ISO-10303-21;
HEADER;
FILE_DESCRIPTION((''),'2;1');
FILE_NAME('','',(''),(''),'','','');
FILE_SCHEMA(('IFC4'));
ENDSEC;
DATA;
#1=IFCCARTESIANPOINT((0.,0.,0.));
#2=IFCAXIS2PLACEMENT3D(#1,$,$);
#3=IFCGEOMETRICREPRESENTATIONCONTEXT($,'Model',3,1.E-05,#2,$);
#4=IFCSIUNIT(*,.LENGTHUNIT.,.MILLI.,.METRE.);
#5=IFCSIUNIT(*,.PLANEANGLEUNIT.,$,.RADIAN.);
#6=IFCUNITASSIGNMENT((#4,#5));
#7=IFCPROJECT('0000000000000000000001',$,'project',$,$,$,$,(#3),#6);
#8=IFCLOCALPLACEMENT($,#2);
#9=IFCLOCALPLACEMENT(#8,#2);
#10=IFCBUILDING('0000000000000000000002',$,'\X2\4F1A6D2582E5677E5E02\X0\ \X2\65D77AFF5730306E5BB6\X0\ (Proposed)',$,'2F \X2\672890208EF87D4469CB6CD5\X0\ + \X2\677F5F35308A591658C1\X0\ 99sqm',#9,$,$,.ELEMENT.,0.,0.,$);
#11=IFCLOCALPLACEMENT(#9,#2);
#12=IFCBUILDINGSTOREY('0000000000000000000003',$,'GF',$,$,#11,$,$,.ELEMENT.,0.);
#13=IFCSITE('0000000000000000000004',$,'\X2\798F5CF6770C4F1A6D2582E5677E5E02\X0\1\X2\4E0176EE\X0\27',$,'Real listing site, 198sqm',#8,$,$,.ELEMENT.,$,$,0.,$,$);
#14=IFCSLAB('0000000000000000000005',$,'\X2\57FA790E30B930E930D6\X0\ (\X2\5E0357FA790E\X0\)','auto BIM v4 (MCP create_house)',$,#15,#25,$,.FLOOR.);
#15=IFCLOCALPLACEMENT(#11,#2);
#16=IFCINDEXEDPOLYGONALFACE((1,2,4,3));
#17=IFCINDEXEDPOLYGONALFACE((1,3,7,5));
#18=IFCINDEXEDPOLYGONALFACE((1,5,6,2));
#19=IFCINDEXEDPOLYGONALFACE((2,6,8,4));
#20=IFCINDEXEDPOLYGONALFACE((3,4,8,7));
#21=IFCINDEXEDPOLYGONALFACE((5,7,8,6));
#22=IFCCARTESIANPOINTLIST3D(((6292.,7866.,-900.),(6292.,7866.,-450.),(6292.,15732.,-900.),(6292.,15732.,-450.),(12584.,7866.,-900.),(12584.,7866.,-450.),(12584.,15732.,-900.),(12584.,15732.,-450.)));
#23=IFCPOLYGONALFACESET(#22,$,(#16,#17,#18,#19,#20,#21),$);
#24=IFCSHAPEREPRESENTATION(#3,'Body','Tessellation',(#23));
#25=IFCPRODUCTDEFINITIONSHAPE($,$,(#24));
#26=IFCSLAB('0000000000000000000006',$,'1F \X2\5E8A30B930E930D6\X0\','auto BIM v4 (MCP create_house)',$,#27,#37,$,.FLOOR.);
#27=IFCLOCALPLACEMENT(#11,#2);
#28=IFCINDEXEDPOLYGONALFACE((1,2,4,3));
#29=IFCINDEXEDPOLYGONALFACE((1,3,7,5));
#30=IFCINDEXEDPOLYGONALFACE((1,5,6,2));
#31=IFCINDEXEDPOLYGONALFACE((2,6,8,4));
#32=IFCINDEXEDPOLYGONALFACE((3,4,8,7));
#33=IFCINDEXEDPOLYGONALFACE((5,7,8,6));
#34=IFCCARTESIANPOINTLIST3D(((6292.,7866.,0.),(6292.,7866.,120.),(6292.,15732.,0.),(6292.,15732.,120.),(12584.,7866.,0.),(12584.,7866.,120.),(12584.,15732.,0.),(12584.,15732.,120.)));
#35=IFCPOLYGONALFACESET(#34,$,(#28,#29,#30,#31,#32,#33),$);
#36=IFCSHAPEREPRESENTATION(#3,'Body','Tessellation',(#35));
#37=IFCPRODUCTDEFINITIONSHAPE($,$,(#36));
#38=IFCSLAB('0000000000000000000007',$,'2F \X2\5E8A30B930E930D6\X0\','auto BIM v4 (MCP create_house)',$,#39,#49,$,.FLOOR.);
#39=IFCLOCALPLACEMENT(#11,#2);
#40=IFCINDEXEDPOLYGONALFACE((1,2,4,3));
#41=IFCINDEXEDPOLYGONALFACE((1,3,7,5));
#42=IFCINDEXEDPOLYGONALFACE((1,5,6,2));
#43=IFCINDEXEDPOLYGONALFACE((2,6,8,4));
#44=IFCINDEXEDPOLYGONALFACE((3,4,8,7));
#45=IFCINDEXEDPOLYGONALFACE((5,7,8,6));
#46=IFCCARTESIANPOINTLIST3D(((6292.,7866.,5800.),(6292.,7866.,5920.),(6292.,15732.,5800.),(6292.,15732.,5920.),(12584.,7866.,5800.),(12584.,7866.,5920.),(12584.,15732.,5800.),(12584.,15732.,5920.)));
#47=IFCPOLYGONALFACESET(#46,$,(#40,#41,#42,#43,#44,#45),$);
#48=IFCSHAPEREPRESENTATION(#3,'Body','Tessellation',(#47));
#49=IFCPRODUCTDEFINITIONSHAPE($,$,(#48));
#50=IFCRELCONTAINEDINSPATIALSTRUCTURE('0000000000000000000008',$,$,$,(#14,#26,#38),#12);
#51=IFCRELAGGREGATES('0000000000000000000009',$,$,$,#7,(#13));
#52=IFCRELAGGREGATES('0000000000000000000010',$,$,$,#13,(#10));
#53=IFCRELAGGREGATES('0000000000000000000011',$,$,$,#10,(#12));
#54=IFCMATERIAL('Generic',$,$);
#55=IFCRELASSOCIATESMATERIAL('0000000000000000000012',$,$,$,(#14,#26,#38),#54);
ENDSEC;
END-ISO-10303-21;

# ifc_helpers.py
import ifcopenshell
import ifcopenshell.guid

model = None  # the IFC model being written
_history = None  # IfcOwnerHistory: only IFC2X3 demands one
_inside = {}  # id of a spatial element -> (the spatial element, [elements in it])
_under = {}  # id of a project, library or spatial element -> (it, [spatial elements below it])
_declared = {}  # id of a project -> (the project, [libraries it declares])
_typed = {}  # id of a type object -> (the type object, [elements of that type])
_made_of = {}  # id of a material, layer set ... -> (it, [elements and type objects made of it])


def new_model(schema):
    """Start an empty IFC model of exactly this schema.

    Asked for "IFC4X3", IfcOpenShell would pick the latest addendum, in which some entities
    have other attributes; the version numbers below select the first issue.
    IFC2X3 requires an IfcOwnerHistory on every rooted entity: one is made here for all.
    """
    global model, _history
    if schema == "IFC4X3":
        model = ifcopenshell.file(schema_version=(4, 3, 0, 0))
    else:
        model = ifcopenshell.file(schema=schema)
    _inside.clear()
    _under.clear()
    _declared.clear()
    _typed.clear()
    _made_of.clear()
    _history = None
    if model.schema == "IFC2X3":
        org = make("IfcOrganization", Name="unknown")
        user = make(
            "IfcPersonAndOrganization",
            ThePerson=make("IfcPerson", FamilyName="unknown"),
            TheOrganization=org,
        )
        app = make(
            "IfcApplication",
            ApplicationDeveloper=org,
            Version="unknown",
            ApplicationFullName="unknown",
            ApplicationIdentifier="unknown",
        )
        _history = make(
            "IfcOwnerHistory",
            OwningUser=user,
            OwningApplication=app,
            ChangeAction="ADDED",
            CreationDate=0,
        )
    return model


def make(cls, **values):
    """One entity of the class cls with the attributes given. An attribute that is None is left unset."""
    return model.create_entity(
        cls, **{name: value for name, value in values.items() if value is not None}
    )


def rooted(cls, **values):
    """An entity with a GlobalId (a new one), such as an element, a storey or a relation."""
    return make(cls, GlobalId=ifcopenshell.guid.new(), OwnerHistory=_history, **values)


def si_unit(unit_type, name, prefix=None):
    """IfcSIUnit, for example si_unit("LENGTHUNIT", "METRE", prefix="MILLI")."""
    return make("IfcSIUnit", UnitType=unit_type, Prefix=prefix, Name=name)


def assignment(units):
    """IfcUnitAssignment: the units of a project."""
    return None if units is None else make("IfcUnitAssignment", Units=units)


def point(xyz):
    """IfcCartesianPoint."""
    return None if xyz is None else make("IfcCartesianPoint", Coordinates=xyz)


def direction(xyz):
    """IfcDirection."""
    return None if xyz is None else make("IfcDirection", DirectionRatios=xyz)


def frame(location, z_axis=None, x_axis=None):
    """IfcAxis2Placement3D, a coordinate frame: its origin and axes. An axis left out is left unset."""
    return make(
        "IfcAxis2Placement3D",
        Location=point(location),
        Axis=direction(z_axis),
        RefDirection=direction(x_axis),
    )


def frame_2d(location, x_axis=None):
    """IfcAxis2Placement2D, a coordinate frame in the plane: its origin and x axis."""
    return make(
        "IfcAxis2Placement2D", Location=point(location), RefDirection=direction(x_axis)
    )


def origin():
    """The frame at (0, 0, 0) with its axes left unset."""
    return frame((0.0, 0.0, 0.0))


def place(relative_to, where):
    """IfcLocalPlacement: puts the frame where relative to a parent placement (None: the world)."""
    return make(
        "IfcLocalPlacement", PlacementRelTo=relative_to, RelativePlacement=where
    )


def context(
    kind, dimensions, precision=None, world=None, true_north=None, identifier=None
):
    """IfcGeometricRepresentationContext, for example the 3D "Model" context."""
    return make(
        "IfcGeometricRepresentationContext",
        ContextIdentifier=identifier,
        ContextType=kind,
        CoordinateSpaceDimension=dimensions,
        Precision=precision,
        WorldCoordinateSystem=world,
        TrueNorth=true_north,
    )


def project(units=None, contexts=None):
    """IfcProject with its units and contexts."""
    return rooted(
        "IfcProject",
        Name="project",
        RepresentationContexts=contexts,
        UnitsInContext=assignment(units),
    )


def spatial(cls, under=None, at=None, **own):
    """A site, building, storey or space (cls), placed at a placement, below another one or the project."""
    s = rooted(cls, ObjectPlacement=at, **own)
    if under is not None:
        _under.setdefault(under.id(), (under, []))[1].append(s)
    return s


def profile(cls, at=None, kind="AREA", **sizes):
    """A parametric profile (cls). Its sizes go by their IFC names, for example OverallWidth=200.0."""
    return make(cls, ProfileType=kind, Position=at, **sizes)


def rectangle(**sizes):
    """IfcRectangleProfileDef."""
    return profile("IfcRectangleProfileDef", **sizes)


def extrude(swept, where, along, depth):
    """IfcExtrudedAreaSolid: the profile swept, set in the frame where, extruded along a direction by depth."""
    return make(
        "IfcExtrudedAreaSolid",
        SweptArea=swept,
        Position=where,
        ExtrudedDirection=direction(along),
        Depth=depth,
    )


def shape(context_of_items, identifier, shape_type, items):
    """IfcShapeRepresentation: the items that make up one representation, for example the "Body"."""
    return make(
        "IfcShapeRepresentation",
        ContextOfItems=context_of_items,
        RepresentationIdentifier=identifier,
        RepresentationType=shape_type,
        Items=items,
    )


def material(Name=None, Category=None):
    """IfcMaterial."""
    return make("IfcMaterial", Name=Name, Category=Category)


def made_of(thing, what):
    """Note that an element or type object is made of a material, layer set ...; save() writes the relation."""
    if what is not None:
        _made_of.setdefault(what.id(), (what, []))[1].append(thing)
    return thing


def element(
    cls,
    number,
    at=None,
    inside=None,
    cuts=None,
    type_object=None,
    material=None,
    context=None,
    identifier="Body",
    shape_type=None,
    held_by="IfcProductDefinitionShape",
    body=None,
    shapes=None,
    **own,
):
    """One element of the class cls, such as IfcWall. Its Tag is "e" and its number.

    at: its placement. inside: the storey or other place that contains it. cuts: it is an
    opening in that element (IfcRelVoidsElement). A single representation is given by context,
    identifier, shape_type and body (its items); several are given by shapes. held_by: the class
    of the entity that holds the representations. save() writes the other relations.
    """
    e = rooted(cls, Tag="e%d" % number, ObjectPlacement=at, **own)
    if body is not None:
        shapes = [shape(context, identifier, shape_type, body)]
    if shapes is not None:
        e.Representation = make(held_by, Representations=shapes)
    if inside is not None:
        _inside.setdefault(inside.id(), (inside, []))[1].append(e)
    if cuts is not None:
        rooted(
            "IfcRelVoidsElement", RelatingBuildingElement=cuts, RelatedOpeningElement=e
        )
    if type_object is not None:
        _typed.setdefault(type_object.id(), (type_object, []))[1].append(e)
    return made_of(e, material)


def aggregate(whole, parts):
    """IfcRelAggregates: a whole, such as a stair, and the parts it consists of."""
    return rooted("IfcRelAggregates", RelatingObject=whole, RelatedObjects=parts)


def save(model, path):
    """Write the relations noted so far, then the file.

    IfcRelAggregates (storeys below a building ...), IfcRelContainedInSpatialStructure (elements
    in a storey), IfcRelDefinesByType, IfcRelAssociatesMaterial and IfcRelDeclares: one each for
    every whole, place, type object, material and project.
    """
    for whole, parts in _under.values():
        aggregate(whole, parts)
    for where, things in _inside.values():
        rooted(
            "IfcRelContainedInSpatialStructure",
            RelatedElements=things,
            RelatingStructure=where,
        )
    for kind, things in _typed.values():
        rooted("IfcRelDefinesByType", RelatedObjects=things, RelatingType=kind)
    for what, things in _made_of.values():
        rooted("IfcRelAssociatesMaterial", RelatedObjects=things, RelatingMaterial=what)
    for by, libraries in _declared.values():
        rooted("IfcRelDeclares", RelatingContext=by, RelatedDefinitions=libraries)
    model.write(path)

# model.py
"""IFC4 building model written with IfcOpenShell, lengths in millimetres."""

from ifc_helpers import new_model, si_unit, frame, frame_2d, origin, place, context, project, spatial, rectangle, extrude, material, element, save


model = new_model("IFC4")

# Units and contexts
model_context = context("Model", 3, precision=1e-05, world=origin())
ifc_project = project(units=[si_unit("LENGTHUNIT", "METRE", prefix="MILLI"), si_unit("PLANEANGLEUNIT", "RADIAN")], contexts=[model_context])

# Site, building, storey
site_placement = place(None, origin())
site = spatial("IfcSite", under=ifc_project, at=site_placement, Name="福島県会津若松市1丁目27", ObjectType="Real listing site, 198sqm", CompositionType="ELEMENT", RefElevation=0.0)
building_placement = place(site_placement, origin())
building = spatial("IfcBuilding", under=site, at=building_placement, Name="会津若松市 旗竿地の家 (Proposed)", ObjectType="2F 木造軸組構法 + 板張り外壁 99sqm", CompositionType="ELEMENT", ElevationOfRefHeight=0.0, ElevationOfTerrain=0.0)
storey_placement = place(building_placement, origin())
storey = spatial("IfcBuildingStorey", under=building, at=storey_placement, Name="GF", CompositionType="ELEMENT", Elevation=0.0)

# Slabs
ifc_material = material(Name="Generic")
slab_1_placement = place(storey_placement, frame((3146.0, 3933.0, -450.0)))
element("IfcSlab", 1, at=slab_1_placement, inside=storey, material=ifc_material, Name="基礎スラブ (布基礎)", Description="auto BIM v4 (MCP create_house)", PredefinedType="FLOOR", context=model_context, shape_type="SweptSolid", body=[
    extrude(rectangle(XDim=6292.0, YDim=7866.0, at=frame_2d((3146.0, 3933.0))), frame((3146.0, 3933.0, -450.0)), (0.0, 0.0, 1.0), 450.0),
])
slab_2_placement = place(storey_placement, frame((3146.0, 3933.0, 0.0)))
element("IfcSlab", 2, at=slab_2_placement, inside=storey, material=ifc_material, Name="1F 床スラブ", Description="auto BIM v4 (MCP create_house)", PredefinedType="FLOOR", context=model_context, shape_type="SweptSolid", body=[
    extrude(rectangle(XDim=6292.0, YDim=7866.0, at=frame_2d((3146.0, 3933.0))), frame((3146.0, 3933.0, 0.0)), (0.0, 0.0, 1.0), 120.0),
])
slab_3_placement = place(storey_placement, frame((3146.0, 3933.0, 2900.0)))
element("IfcSlab", 3, at=slab_3_placement, inside=storey, material=ifc_material, Name="2F 床スラブ", Description="auto BIM v4 (MCP create_house)", PredefinedType="FLOOR", context=model_context, shape_type="SweptSolid", body=[
    extrude(rectangle(XDim=6292.0, YDim=7866.0, at=frame_2d((3146.0, 3933.0))), frame((3146.0, 3933.0, 2900.0)), (0.0, 0.0, 1.0), 120.0),
])

save(model, "model.ifc")
